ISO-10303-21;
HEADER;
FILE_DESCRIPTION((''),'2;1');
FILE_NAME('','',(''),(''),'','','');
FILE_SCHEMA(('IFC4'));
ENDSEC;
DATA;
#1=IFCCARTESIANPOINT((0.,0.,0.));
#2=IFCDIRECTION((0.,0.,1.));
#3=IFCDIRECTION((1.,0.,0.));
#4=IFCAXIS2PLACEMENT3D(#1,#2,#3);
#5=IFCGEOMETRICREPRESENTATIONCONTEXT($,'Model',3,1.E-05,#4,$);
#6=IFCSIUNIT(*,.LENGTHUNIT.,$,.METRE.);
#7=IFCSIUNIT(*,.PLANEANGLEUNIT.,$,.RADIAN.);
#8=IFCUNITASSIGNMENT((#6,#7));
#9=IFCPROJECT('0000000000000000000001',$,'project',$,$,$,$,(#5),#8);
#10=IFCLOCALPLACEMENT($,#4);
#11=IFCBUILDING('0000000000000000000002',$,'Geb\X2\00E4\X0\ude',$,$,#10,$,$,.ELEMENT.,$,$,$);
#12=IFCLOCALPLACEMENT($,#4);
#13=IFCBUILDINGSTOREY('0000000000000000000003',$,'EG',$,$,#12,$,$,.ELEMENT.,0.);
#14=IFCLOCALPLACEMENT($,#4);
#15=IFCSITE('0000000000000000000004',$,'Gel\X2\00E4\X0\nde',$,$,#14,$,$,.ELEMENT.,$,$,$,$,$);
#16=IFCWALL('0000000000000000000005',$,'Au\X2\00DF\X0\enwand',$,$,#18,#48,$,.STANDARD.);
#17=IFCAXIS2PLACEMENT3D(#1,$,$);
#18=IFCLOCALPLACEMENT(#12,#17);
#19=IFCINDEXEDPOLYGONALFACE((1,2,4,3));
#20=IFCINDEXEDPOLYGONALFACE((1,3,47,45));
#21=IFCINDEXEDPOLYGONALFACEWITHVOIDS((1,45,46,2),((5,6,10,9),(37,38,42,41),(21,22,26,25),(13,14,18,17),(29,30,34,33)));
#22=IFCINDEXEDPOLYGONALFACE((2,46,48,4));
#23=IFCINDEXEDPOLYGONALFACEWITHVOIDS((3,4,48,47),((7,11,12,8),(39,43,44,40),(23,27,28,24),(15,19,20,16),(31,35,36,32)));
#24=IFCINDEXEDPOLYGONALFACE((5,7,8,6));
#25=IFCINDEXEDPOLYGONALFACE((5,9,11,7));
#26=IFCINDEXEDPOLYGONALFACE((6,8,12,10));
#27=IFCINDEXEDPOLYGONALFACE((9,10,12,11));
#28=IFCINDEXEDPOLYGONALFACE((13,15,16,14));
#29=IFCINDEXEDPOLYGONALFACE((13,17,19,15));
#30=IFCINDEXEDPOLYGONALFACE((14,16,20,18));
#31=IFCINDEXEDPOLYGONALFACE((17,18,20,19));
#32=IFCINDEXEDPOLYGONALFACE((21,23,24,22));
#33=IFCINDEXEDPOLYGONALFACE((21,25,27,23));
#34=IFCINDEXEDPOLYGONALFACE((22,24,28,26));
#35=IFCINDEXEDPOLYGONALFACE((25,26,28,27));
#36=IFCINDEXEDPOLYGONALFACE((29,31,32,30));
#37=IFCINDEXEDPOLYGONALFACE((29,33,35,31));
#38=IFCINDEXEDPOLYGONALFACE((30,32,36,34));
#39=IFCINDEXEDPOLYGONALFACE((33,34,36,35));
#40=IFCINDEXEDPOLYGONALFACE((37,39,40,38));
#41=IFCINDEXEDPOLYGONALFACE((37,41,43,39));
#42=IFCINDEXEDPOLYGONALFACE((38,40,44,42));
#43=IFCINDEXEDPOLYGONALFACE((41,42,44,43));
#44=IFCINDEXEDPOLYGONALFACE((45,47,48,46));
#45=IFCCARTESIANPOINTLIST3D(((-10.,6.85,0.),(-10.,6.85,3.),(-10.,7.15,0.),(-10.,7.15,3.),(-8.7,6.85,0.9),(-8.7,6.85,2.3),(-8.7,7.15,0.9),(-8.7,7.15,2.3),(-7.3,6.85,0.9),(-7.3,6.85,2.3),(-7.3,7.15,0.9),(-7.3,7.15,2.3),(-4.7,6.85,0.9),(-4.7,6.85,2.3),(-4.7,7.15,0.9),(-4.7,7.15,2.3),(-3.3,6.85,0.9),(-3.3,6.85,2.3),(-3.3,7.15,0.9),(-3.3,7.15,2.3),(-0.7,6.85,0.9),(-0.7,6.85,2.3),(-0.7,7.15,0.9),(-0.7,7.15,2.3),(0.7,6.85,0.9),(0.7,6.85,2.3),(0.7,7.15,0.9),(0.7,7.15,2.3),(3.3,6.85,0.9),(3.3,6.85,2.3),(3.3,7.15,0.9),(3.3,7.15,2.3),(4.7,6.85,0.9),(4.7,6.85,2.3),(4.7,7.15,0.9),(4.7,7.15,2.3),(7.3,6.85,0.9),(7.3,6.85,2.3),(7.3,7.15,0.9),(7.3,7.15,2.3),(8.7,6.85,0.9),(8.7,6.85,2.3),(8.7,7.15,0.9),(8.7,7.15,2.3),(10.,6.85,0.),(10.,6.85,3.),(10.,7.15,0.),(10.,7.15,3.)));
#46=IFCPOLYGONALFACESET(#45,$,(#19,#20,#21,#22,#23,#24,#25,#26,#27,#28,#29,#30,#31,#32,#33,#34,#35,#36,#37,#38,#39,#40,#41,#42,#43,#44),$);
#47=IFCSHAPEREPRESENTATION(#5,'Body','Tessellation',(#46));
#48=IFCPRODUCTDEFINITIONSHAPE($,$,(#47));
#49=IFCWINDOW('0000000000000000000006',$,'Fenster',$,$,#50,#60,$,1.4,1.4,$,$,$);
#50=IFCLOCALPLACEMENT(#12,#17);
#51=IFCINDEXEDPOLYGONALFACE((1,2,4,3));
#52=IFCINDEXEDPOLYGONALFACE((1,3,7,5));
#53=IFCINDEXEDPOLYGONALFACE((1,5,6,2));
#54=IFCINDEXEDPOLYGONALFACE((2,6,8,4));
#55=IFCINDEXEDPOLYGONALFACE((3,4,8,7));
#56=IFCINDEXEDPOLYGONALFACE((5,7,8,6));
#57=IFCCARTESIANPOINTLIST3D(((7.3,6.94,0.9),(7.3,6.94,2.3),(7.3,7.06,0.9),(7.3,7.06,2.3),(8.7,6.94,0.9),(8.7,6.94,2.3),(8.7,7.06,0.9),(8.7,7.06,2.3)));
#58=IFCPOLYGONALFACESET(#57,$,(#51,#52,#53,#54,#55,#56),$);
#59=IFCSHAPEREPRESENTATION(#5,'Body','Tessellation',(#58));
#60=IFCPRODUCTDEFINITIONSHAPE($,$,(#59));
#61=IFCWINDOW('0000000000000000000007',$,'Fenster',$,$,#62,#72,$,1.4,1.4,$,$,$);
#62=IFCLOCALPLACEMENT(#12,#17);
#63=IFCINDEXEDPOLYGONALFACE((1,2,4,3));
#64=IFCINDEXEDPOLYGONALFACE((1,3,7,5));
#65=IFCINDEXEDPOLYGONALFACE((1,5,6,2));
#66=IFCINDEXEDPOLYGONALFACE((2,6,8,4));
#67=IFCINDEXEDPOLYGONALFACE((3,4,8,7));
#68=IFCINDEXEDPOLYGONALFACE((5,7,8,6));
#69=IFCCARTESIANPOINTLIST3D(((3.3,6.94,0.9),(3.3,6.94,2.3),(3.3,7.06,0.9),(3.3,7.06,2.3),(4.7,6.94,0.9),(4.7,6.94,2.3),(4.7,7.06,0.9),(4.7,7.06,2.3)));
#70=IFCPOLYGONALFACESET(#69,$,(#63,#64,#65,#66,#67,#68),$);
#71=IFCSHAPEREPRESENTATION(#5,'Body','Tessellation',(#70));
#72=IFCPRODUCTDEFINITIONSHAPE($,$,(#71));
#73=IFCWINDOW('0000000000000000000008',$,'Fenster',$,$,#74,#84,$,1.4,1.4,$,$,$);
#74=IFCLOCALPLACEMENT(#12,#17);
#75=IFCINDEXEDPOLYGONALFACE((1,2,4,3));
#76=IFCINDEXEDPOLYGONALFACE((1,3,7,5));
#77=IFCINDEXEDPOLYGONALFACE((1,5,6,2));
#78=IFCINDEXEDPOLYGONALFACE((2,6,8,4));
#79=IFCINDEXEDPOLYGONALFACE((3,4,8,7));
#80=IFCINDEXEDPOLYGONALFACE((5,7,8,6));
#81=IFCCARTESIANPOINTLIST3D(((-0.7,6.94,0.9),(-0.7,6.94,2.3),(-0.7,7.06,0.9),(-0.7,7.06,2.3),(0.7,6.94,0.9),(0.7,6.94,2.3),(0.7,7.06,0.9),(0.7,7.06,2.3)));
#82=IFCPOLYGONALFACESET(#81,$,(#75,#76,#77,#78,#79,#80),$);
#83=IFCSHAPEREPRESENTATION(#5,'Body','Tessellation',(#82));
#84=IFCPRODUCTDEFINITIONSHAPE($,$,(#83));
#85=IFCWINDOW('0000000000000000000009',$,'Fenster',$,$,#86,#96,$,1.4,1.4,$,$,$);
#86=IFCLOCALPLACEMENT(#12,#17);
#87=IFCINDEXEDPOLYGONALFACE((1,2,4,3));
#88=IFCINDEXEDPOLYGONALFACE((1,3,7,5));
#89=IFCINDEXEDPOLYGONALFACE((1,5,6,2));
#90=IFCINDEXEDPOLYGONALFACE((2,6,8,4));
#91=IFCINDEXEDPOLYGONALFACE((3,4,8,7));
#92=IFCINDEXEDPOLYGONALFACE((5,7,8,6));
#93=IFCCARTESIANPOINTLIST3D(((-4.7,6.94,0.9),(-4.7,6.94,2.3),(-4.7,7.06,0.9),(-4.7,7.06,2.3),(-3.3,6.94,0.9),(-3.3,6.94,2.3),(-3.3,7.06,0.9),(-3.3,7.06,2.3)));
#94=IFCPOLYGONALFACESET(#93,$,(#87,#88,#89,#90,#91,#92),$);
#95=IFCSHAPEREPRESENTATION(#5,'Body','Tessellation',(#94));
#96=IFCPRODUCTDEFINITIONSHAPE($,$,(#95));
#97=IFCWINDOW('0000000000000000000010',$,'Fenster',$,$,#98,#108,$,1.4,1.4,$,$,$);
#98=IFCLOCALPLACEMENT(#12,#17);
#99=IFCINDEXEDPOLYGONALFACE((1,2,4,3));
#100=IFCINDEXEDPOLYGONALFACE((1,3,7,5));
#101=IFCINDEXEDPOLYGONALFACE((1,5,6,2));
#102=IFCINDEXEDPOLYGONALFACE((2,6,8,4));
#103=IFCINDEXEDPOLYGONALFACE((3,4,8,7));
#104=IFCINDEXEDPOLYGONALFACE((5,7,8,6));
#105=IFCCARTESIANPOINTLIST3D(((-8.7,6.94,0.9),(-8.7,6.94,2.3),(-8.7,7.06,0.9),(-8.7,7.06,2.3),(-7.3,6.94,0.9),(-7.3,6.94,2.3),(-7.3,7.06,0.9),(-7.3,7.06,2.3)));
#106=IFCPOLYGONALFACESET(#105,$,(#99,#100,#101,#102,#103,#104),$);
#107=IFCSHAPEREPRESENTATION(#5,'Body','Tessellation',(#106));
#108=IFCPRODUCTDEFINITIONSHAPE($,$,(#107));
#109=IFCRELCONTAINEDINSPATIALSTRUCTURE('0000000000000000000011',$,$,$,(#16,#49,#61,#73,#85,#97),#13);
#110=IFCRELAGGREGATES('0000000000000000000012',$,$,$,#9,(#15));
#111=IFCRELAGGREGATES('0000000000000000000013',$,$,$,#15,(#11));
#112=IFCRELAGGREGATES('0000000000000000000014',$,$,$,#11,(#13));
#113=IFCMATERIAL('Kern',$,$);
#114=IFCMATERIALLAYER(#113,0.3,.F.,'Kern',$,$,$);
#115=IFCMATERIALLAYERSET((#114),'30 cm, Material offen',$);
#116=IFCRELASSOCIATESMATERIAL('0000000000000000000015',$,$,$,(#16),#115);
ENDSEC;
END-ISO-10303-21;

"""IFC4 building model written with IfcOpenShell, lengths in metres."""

from ifc_helpers import new_model, si_unit, frame, origin_with_axes, origin_2d, place, context, project, spatial, rectangle, extrude, material, layer, layer_set, element, fill, save


model = new_model("IFC4")

# Units and contexts
model_context = context("Model", 3, precision=1e-05, world=origin_with_axes())
ifc_project = project(units=[si_unit("LENGTHUNIT", "METRE"), si_unit("PLANEANGLEUNIT", "RADIAN")], contexts=[model_context])

# Site, building, storey
site_placement = place(None, origin_with_axes())
site = spatial("IfcSite", under=ifc_project, at=site_placement, Name="Gelände", CompositionType="ELEMENT")
building_placement = place(None, origin_with_axes())
building = spatial("IfcBuilding", under=site, at=building_placement, Name="Gebäude", CompositionType="ELEMENT")
storey_placement = place(None, origin_with_axes())
storey = spatial("IfcBuildingStorey", under=building, at=storey_placement, Name="EG", CompositionType="ELEMENT", Elevation=0.0)

# Wall, openings, windows
ifc_material = material(Name="Kern")
ifc_layer = layer(ifc_material, 0.3, ventilated=False, Name="Kern")
ifc_layer_set = layer_set([ifc_layer], Name="30 cm, Material offen")
wall_1_placement = place(None, frame((0.0, 7.0, 0.0), z_axis=(0.0, 0.0, 1.0), x_axis=(-1.0, 0.0, 0.0)))
wall_1 = element("IfcWall", 1, at=wall_1_placement, inside=storey, material=ifc_layer_set, Name="Außenwand", PredefinedType="STANDARD", context=model_context, shape_type="SweptSolid", body=[
    extrude(rectangle(XDim=20.0, YDim=0.3, at=origin_2d()), origin_with_axes(), (0.0, 0.0, 1.0), 3.0),
])
opening_1_placement = place(wall_1_placement, frame((-8.0, 0.0, 0.9), z_axis=(0.0, 0.0, 1.0), x_axis=(1.0, 0.0, 0.0)))
opening_1 = element("IfcOpeningElement", 2, at=opening_1_placement, cuts=wall_1, PredefinedType="OPENING", context=model_context, shape_type="SweptSolid", body=[
    extrude(rectangle(XDim=1.4, YDim=0.34, at=origin_2d()), origin_with_axes(), (0.0, 0.0, 1.0), 1.4),
])
opening_2_placement = place(wall_1_placement, frame((-4.0, 0.0, 0.9), z_axis=(0.0, 0.0, 1.0), x_axis=(1.0, 0.0, 0.0)))
opening_2 = element("IfcOpeningElement", 3, at=opening_2_placement, cuts=wall_1, PredefinedType="OPENING", context=model_context, shape_type="SweptSolid", body=[
    extrude(rectangle(XDim=1.4, YDim=0.34, at=origin_2d()), origin_with_axes(), (0.0, 0.0, 1.0), 1.4),
])
opening_3_placement = place(wall_1_placement, frame((0.0, 0.0, 0.9), z_axis=(0.0, 0.0, 1.0), x_axis=(1.0, 0.0, 0.0)))
opening_3 = element("IfcOpeningElement", 4, at=opening_3_placement, cuts=wall_1, PredefinedType="OPENING", context=model_context, shape_type="SweptSolid", body=[
    extrude(rectangle(XDim=1.4, YDim=0.34, at=origin_2d()), origin_with_axes(), (0.0, 0.0, 1.0), 1.4),
])
opening_4_placement = place(wall_1_placement, frame((4.0, 0.0, 0.9), z_axis=(0.0, 0.0, 1.0), x_axis=(1.0, 0.0, 0.0)))
opening_4 = element("IfcOpeningElement", 5, at=opening_4_placement, cuts=wall_1, PredefinedType="OPENING", context=model_context, shape_type="SweptSolid", body=[
    extrude(rectangle(XDim=1.4, YDim=0.34, at=origin_2d()), origin_with_axes(), (0.0, 0.0, 1.0), 1.4),
])
opening_5_placement = place(wall_1_placement, frame((8.0, 0.0, 0.9), z_axis=(0.0, 0.0, 1.0), x_axis=(1.0, 0.0, 0.0)))
opening_5 = element("IfcOpeningElement", 6, at=opening_5_placement, cuts=wall_1, PredefinedType="OPENING", context=model_context, shape_type="SweptSolid", body=[
    extrude(rectangle(XDim=1.4, YDim=0.34, at=origin_2d()), origin_with_axes(), (0.0, 0.0, 1.0), 1.4),
])
window_1_placement = place(opening_1_placement, origin_with_axes())
window_1 = element("IfcWindow", 7, at=window_1_placement, inside=storey, Name="Fenster", OverallHeight=1.4, OverallWidth=1.4, context=model_context, shape_type="SweptSolid", body=[
    extrude(rectangle(XDim=1.4, YDim=0.12, at=origin_2d()), origin_with_axes(), (0.0, 0.0, 1.0), 1.4),
])
fill(opening_1, window_1)
window_2_placement = place(opening_2_placement, origin_with_axes())
window_2 = element("IfcWindow", 8, at=window_2_placement, inside=storey, Name="Fenster", OverallHeight=1.4, OverallWidth=1.4, context=model_context, shape_type="SweptSolid", body=[
    extrude(rectangle(XDim=1.4, YDim=0.12, at=origin_2d()), origin_with_axes(), (0.0, 0.0, 1.0), 1.4),
])
fill(opening_2, window_2)
window_3_placement = place(opening_3_placement, origin_with_axes())
window_3 = element("IfcWindow", 9, at=window_3_placement, inside=storey, Name="Fenster", OverallHeight=1.4, OverallWidth=1.4, context=model_context, shape_type="SweptSolid", body=[
    extrude(rectangle(XDim=1.4, YDim=0.12, at=origin_2d()), origin_with_axes(), (0.0, 0.0, 1.0), 1.4),
])
fill(opening_3, window_3)
window_4_placement = place(opening_4_placement, origin_with_axes())
window_4 = element("IfcWindow", 10, at=window_4_placement, inside=storey, Name="Fenster", OverallHeight=1.4, OverallWidth=1.4, context=model_context, shape_type="SweptSolid", body=[
    extrude(rectangle(XDim=1.4, YDim=0.12, at=origin_2d()), origin_with_axes(), (0.0, 0.0, 1.0), 1.4),
])
fill(opening_4, window_4)
window_5_placement = place(opening_5_placement, origin_with_axes())
window_5 = element("IfcWindow", 11, at=window_5_placement, inside=storey, Name="Fenster", OverallHeight=1.4, OverallWidth=1.4, context=model_context, shape_type="SweptSolid", body=[
    extrude(rectangle(XDim=1.4, YDim=0.12, at=origin_2d()), origin_with_axes(), (0.0, 0.0, 1.0), 1.4),
])
fill(opening_5, window_5)

save(model, "model.ifc")
